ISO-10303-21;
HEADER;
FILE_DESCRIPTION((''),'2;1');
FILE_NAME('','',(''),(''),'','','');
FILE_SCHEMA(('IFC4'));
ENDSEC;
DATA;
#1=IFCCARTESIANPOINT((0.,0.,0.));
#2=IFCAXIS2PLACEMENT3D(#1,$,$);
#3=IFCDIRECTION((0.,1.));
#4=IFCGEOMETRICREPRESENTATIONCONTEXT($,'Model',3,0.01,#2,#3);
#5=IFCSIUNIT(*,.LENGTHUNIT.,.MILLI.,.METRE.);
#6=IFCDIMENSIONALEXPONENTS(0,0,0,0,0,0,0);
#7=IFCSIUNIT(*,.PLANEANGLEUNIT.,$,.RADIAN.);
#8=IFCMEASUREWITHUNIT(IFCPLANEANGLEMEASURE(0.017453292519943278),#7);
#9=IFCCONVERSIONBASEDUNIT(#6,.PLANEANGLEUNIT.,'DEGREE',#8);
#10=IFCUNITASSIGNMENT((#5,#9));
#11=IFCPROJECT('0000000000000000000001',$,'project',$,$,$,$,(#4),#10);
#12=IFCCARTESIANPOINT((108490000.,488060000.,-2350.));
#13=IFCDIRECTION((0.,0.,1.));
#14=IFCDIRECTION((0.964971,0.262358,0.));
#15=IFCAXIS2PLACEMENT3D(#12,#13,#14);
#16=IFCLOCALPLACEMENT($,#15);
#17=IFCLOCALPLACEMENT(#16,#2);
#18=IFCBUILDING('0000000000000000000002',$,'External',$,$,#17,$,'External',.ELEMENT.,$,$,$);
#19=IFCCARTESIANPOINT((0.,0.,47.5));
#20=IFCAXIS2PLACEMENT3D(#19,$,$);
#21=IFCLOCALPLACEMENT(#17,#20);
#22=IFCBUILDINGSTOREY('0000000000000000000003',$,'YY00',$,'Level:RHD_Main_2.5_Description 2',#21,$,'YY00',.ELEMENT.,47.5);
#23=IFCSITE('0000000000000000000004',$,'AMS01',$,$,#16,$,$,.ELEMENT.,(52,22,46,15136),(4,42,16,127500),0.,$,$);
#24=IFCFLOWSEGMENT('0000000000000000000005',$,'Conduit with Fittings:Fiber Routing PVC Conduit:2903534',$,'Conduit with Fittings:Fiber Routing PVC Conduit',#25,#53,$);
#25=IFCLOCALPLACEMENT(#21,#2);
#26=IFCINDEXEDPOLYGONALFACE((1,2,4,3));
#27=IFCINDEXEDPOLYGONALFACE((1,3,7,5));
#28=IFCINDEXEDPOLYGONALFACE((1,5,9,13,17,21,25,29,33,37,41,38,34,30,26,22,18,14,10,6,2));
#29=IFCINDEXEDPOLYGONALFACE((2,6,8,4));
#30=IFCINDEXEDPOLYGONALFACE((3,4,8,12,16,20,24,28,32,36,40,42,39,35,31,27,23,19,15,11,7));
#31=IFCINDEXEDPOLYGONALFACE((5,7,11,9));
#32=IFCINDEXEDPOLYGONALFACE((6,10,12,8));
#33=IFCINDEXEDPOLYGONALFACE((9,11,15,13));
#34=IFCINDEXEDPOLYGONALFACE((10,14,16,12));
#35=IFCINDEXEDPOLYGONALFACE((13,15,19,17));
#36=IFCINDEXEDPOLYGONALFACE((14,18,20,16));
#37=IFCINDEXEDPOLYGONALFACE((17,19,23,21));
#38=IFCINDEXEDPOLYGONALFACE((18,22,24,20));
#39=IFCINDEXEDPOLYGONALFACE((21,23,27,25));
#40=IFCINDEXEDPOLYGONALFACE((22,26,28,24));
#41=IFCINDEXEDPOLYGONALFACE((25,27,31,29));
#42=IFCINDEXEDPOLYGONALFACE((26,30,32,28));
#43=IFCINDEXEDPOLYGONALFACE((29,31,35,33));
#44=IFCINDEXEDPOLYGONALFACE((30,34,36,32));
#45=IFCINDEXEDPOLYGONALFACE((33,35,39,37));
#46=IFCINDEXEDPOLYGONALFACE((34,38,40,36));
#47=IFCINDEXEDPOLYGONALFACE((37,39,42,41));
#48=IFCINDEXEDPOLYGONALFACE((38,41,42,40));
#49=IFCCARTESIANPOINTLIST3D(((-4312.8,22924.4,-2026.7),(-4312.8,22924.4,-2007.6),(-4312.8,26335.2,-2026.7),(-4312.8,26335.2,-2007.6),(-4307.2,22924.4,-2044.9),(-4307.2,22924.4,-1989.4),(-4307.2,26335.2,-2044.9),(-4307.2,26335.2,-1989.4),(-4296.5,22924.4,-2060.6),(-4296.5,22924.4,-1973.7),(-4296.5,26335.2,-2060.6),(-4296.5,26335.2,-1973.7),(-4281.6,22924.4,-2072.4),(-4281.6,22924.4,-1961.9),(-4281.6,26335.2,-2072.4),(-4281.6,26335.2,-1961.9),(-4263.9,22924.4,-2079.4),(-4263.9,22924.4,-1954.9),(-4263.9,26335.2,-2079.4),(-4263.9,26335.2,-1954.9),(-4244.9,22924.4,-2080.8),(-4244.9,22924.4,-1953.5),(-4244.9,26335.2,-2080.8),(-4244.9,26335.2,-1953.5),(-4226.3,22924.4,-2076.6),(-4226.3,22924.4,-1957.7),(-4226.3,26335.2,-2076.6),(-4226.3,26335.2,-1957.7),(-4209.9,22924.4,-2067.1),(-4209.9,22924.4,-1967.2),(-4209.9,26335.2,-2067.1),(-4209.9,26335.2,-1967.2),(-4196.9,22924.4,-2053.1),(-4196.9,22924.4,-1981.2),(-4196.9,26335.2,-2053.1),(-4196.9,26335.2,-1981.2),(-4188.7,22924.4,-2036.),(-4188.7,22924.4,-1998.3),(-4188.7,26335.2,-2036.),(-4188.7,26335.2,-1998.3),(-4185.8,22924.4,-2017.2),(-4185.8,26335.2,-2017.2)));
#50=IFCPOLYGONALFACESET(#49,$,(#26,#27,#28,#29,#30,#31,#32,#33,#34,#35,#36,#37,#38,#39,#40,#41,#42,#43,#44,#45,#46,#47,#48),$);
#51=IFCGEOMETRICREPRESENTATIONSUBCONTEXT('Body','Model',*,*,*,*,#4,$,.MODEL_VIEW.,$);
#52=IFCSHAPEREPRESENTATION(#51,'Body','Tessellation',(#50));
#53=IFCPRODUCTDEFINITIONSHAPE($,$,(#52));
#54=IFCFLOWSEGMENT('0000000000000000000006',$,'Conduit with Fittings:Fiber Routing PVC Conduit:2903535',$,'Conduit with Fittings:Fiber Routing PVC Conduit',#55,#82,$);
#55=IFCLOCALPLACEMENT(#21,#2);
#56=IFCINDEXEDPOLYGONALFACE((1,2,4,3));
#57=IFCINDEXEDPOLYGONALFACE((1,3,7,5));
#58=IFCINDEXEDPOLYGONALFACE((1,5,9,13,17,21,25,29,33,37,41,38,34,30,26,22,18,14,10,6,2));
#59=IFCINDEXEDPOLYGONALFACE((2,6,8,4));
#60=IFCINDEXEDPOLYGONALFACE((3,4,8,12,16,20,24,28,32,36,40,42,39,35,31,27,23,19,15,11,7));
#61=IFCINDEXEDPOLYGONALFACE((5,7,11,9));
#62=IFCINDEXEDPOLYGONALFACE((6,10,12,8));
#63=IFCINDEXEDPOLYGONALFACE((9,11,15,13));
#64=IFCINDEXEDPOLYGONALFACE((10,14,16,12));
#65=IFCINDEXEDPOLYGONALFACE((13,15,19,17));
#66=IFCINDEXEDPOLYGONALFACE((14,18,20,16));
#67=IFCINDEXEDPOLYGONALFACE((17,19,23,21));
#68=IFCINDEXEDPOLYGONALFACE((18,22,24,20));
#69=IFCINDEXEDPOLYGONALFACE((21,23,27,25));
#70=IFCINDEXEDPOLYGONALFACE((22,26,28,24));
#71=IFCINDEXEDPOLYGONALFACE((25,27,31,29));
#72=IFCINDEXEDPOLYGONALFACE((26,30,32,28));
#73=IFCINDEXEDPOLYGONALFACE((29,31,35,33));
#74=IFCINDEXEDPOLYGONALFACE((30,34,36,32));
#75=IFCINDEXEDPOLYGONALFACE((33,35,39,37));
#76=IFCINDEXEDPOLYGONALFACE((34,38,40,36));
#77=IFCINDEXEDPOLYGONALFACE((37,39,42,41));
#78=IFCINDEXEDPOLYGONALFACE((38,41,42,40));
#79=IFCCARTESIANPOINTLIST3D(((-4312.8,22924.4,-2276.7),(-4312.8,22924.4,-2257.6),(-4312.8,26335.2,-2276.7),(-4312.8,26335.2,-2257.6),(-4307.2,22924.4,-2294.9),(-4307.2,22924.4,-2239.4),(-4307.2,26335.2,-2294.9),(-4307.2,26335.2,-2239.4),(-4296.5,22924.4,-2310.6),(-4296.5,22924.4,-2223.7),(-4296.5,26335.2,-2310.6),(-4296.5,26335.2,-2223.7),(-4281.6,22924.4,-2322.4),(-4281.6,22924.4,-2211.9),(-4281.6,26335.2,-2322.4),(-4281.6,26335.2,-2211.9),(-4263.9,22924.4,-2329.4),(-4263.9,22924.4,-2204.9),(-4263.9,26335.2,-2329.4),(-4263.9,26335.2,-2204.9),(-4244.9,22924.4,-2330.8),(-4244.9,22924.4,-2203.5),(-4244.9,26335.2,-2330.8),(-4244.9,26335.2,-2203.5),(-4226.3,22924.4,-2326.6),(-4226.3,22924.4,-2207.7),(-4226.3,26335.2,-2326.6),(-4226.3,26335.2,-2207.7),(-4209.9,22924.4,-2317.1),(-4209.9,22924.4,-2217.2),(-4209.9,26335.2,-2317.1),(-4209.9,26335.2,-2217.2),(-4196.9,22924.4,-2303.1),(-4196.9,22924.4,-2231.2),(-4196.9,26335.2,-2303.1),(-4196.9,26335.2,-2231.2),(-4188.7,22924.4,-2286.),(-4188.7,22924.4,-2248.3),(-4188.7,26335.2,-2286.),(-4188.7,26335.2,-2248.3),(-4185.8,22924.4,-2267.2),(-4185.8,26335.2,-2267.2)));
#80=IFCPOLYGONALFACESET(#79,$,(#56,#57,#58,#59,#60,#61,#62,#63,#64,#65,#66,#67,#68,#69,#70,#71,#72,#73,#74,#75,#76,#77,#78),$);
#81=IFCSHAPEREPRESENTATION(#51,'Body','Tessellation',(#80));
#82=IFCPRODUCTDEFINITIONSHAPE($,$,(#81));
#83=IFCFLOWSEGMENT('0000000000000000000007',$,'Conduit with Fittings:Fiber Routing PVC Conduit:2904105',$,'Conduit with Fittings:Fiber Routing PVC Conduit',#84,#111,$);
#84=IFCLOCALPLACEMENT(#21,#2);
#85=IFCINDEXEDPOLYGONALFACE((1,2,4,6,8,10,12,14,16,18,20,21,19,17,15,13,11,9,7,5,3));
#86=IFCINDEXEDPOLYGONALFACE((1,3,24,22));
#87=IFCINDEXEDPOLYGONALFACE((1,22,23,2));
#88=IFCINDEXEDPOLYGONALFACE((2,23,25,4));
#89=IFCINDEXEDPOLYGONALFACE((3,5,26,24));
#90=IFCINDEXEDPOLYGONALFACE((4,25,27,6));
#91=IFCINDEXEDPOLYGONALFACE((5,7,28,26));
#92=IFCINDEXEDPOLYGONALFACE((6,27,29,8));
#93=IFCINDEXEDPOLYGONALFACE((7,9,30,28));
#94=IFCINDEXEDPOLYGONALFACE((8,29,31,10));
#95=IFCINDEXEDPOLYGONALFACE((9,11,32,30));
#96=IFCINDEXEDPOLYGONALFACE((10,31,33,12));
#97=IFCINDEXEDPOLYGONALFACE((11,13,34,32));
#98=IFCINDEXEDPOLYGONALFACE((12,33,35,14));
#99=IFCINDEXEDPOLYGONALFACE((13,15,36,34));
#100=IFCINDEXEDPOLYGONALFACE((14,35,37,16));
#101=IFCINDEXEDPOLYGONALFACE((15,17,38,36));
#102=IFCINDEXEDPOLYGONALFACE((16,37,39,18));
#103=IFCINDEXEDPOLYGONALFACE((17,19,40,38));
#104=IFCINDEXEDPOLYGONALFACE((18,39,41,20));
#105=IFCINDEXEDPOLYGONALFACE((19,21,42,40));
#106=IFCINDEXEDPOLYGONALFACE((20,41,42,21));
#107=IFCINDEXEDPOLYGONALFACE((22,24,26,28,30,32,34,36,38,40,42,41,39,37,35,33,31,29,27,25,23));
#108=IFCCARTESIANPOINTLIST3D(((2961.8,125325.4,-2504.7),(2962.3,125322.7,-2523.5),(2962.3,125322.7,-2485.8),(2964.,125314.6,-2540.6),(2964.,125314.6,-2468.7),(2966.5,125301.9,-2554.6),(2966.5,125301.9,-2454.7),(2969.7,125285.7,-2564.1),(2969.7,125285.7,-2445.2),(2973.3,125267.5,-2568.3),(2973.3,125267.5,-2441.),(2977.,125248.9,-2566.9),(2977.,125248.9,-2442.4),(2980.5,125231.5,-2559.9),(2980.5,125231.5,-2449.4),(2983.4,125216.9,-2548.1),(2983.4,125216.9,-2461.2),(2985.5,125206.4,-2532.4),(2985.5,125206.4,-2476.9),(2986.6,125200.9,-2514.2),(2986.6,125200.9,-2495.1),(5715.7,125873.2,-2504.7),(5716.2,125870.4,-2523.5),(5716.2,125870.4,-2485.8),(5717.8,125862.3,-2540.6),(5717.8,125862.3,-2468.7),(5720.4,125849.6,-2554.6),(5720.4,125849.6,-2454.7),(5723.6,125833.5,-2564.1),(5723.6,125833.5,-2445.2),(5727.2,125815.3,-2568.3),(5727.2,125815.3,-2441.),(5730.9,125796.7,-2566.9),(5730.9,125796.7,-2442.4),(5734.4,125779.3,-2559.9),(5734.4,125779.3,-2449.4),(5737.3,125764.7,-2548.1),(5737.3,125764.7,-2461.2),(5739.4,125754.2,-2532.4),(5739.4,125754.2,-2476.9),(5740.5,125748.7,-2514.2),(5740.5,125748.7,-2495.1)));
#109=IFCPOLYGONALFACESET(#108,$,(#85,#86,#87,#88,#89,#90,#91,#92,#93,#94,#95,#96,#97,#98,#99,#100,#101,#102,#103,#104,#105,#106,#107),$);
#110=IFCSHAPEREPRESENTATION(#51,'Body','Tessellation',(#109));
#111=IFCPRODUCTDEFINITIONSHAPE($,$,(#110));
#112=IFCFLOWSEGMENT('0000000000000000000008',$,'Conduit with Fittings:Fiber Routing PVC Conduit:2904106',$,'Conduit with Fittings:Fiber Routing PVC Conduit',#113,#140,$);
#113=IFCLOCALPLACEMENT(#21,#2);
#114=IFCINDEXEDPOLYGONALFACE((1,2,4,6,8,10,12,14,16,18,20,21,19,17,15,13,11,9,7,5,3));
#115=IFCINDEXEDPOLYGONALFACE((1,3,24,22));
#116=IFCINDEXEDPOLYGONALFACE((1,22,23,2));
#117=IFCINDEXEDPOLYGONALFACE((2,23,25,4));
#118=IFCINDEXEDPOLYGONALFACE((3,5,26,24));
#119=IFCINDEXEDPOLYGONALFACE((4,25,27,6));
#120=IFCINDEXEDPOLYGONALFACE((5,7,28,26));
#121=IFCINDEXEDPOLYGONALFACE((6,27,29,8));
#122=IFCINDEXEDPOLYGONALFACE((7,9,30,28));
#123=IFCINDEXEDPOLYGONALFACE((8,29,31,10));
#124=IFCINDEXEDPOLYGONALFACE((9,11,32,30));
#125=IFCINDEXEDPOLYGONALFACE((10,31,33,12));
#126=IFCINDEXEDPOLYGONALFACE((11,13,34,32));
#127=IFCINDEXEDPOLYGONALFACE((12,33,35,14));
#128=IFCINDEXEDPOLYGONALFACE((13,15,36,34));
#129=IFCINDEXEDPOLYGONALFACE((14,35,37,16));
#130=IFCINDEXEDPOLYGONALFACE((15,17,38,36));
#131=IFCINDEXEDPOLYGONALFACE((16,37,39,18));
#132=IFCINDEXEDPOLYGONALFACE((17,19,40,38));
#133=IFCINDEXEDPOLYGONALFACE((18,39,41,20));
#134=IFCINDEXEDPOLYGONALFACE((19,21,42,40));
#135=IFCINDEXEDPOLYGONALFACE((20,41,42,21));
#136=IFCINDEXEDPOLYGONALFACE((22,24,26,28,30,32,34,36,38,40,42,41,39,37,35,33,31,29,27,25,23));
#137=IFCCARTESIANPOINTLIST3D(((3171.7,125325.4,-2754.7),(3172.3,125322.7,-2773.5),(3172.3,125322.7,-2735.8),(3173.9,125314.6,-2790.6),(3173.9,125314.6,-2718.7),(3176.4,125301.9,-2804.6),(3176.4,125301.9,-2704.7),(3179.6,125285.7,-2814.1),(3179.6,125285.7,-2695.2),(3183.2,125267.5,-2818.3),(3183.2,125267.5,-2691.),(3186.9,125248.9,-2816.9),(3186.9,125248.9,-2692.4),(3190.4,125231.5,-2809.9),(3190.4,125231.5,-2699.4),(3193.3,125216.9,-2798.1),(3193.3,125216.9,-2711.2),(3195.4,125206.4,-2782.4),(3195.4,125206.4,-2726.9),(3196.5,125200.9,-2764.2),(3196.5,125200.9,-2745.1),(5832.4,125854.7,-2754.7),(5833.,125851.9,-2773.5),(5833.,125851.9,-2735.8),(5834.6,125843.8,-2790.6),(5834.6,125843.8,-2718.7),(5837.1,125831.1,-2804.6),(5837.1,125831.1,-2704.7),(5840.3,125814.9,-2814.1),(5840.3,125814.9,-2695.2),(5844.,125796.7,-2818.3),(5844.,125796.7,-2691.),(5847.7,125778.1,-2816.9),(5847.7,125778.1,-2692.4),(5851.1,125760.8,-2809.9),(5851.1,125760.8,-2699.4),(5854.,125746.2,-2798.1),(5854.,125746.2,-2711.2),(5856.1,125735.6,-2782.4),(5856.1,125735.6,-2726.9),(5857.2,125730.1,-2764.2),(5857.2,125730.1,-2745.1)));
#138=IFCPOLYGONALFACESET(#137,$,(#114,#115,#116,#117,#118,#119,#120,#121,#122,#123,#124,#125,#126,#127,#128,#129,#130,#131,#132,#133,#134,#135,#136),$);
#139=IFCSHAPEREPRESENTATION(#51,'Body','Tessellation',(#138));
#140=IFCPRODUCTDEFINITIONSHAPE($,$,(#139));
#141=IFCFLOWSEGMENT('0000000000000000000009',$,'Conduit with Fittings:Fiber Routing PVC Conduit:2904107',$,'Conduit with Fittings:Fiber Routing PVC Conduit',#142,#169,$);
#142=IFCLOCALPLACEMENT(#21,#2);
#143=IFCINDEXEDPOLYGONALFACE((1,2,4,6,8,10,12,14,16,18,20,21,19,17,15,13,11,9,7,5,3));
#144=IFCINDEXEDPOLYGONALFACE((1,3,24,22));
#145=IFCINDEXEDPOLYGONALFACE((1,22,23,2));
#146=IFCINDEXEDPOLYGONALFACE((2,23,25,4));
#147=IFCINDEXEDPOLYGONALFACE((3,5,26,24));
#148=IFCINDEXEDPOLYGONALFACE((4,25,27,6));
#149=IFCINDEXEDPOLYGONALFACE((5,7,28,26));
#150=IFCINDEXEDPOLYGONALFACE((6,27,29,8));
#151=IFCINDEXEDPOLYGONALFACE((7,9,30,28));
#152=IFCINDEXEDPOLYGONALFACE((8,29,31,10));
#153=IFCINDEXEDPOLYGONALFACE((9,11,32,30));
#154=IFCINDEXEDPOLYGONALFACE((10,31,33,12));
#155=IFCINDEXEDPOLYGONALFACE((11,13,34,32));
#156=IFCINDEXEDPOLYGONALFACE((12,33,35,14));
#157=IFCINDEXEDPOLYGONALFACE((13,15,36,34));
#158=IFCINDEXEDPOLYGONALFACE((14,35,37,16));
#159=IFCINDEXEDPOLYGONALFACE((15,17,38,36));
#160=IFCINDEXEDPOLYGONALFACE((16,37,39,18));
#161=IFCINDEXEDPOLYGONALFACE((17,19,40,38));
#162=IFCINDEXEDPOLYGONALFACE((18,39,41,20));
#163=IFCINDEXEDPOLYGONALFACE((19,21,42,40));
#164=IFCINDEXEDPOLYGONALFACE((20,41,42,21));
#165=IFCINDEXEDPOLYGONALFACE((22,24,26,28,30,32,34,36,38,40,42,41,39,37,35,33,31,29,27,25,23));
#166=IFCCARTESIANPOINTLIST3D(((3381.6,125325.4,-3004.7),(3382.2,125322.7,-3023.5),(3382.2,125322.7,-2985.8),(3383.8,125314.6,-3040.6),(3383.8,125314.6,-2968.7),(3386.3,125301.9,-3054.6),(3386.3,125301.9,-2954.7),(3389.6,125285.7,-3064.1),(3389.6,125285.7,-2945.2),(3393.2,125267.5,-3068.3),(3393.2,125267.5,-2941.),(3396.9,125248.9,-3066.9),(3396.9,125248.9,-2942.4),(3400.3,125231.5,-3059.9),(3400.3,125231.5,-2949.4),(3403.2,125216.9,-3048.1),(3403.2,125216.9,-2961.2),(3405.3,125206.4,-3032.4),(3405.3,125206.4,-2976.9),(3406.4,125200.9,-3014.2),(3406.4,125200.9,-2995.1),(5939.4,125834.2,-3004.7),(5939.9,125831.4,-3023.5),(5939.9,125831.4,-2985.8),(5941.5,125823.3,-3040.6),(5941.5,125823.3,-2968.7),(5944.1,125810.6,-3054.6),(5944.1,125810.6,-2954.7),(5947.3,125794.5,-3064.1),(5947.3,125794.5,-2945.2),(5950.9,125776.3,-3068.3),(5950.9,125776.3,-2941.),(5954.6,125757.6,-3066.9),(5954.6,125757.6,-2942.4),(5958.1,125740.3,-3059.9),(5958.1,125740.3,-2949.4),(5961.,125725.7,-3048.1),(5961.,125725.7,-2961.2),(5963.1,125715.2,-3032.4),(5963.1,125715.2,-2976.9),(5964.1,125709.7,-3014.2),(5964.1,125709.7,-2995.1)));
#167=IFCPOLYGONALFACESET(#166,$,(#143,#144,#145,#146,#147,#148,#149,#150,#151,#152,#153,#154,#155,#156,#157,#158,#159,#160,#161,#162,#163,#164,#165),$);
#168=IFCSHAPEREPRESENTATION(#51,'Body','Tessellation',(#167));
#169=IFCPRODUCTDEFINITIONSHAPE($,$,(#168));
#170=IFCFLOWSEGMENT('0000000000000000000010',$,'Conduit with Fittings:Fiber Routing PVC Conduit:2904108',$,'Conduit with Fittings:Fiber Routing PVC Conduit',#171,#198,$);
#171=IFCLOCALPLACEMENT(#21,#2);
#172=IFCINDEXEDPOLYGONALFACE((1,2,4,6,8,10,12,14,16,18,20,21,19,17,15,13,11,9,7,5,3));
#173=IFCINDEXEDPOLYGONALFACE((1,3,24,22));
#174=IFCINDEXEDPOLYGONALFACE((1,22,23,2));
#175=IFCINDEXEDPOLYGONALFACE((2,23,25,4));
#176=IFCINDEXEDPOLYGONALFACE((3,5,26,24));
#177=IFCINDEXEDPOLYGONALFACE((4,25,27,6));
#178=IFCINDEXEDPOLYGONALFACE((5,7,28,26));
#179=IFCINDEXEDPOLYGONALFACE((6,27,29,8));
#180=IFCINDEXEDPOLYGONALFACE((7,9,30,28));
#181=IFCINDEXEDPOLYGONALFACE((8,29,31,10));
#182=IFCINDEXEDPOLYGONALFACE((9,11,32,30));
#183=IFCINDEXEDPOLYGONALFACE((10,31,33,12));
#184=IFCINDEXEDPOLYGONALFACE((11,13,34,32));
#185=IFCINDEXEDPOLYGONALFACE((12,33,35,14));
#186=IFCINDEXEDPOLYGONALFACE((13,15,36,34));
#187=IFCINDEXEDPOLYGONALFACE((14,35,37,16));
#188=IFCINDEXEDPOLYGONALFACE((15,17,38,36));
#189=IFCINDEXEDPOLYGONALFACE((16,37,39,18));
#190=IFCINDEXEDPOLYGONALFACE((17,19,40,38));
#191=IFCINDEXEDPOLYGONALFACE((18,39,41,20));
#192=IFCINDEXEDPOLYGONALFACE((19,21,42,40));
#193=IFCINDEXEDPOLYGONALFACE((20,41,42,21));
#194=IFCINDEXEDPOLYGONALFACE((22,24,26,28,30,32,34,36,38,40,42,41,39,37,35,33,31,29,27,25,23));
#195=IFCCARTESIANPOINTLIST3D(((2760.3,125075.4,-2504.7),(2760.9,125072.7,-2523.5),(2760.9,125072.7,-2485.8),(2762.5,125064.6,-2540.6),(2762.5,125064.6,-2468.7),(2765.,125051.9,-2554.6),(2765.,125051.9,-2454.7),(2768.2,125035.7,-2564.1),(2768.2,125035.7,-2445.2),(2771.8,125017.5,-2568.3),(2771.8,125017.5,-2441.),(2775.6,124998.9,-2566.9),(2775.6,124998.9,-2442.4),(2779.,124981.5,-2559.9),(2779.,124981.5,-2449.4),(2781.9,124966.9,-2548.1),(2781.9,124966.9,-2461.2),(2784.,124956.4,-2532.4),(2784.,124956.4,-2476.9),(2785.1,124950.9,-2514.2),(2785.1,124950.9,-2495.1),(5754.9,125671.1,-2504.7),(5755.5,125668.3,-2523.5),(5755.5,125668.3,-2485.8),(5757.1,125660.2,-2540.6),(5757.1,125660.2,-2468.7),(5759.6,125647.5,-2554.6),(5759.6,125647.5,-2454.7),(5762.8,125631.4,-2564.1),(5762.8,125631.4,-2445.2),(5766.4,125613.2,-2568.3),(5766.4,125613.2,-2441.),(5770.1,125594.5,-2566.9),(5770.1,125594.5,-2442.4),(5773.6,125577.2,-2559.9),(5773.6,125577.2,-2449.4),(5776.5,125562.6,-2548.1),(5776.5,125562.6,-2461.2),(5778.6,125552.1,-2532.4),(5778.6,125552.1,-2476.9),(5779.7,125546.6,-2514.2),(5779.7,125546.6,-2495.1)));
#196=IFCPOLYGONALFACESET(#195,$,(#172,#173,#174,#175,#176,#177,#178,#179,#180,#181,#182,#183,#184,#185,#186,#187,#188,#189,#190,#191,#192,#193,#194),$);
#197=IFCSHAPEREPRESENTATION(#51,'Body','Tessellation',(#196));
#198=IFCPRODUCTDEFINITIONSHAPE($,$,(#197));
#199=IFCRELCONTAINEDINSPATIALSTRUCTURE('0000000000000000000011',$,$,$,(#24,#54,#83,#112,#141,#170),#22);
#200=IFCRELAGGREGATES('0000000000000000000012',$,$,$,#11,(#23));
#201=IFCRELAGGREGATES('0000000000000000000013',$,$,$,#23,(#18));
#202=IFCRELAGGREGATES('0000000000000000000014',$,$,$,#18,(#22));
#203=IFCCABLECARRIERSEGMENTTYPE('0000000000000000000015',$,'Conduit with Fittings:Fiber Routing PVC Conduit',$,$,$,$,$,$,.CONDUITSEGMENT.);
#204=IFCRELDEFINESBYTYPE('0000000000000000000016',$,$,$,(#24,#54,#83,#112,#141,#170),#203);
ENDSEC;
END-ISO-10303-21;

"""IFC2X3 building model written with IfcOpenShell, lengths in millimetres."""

from ifc_helpers import new_model, entity, si_unit, converted_unit, direction, frame, frame_2d, origin, origin_2d_with_axis, place, context, subcontext, project, spatial, circle, extrude, type_object, element, save


model = new_model("IFC2X3")

# Units and contexts
model_context = context("Model", 3, precision=0.01, world=origin(), true_north=direction((0.0, 1.0)))
body_context = subcontext(model_context, "Body", "Model", "MODEL_VIEW")
ifc_project = project(units=[si_unit("LENGTHUNIT", "METRE", prefix="MILLI"), converted_unit("PLANEANGLEUNIT", "DEGREE", entity("IfcPlaneAngleMeasure", 0.017453292519943278), si_unit("PLANEANGLEUNIT", "RADIAN"), dimensions=[0, 0, 0, 0, 0, 0, 0])], contexts=[model_context])

# Site, building, storey
site_placement = place(None, frame((108490000.0, 488060000.0, -2350.0), z_axis=(0.0, 0.0, 1.0), x_axis=(0.964971, 0.262358, 0.0)))
site = spatial("IfcSite", under=ifc_project, at=site_placement, Name="AMS01", CompositionType="ELEMENT", RefLatitude=(52, 22, 46, 15136), RefLongitude=(4, 42, 16, 127500), RefElevation=0.0)
building_placement = place(site_placement, origin())
building = spatial("IfcBuilding", under=site, at=building_placement, Name="External", LongName="External", CompositionType="ELEMENT")
storey_placement = place(building_placement, frame((0.0, 0.0, 47.5)))
storey = spatial("IfcBuildingStorey", under=building, at=storey_placement, Name="YY00", ObjectType="Level:RHD_Main_2.5_Description 2", LongName="YY00", CompositionType="ELEMENT", Elevation=47.5)

# Flow segments
cable_carrier_segment_type = type_object("IfcCableCarrierSegmentType", Name="Conduit with Fittings:Fiber Routing PVC Conduit", PredefinedType="CONDUITSEGMENT")
flow_segment_1_placement = place(storey_placement, origin())
element("IfcFlowSegment", 1, at=flow_segment_1_placement, inside=storey, type_object=cable_carrier_segment_type, Name="Conduit with Fittings:Fiber Routing PVC Conduit:2903534", ObjectType="Conduit with Fittings:Fiber Routing PVC Conduit", context=body_context, shape_type="SweptSolid", body=[
    extrude(circle(Radius=63.9, at=origin_2d_with_axis()), frame((-4249.7, 22924.4, -2017.2), z_axis=(0.0, 1.0, 0.0), x_axis=(1.0, 0.0, 0.0)), (0.0, 0.0, 1.0), 3410.8),
])
flow_segment_2_placement = place(storey_placement, origin())
element("IfcFlowSegment", 2, at=flow_segment_2_placement, inside=storey, type_object=cable_carrier_segment_type, Name="Conduit with Fittings:Fiber Routing PVC Conduit:2903535", ObjectType="Conduit with Fittings:Fiber Routing PVC Conduit", context=body_context, shape_type="SweptSolid", body=[
    extrude(circle(Radius=63.9, at=frame_2d((0.0, 0.0), x_axis=(1.0, 0.0))), frame((-4249.7, 22924.4, -2267.2), z_axis=(0.0, 1.0, 0.0), x_axis=(1.0, 0.0, 0.0)), (0.0, 0.0, 1.0), 3410.8),
])
flow_segment_3_placement = place(storey_placement, origin())
element("IfcFlowSegment", 3, at=flow_segment_3_placement, inside=storey, type_object=cable_carrier_segment_type, Name="Conduit with Fittings:Fiber Routing PVC Conduit:2904105", ObjectType="Conduit with Fittings:Fiber Routing PVC Conduit", context=body_context, shape_type="SweptSolid", body=[
    extrude(circle(Radius=63.9, at=frame_2d((0.0, 0.0), x_axis=(1.0, 0.0))), frame((2974.3, 125262.8, -2504.7), z_axis=(0.980785, 0.19509, 0.0), x_axis=(-0.19509, 0.980785, 0.0)), (0.0, 0.0, 1.0), 2807.8),
])
flow_segment_4_placement = place(storey_placement, origin())
element("IfcFlowSegment", 4, at=flow_segment_4_placement, inside=storey, type_object=cable_carrier_segment_type, Name="Conduit with Fittings:Fiber Routing PVC Conduit:2904106", ObjectType="Conduit with Fittings:Fiber Routing PVC Conduit", context=body_context, shape_type="SweptSolid", body=[
    extrude(circle(Radius=63.9, at=frame_2d((0.0, 0.0), x_axis=(1.0, 0.0))), frame((3184.2, 125262.8, -2754.7), z_axis=(0.980785, 0.19509, 0.0), x_axis=(-0.19509, 0.980785, 0.0)), (0.0, 0.0, 1.0), 2712.8),
])
flow_segment_5_placement = place(storey_placement, origin())
element("IfcFlowSegment", 5, at=flow_segment_5_placement, inside=storey, type_object=cable_carrier_segment_type, Name="Conduit with Fittings:Fiber Routing PVC Conduit:2904107", ObjectType="Conduit with Fittings:Fiber Routing PVC Conduit", context=body_context, shape_type="SweptSolid", body=[
    extrude(circle(Radius=63.9, at=frame_2d((0.0, 0.0), x_axis=(1.0, 0.0))), frame((3394.1, 125262.8, -3004.7), z_axis=(0.980785, 0.19509, 0.0), x_axis=(-0.19509, 0.980785, 0.0)), (0.0, 0.0, 1.0), 2607.8),
])
flow_segment_6_placement = place(storey_placement, origin())
element("IfcFlowSegment", 6, at=flow_segment_6_placement, inside=storey, type_object=cable_carrier_segment_type, Name="Conduit with Fittings:Fiber Routing PVC Conduit:2904108", ObjectType="Conduit with Fittings:Fiber Routing PVC Conduit", context=body_context, shape_type="SweptSolid", body=[
    extrude(circle(Radius=63.9, at=frame_2d((0.0, 0.0), x_axis=(1.0, 0.0))), frame((2772.8, 125012.8, -2504.7), z_axis=(0.980785, 0.19509, 0.0), x_axis=(-0.19509, 0.980785, 0.0)), (0.0, 0.0, 1.0), 3053.3),
])

save(model, "model.ifc")
